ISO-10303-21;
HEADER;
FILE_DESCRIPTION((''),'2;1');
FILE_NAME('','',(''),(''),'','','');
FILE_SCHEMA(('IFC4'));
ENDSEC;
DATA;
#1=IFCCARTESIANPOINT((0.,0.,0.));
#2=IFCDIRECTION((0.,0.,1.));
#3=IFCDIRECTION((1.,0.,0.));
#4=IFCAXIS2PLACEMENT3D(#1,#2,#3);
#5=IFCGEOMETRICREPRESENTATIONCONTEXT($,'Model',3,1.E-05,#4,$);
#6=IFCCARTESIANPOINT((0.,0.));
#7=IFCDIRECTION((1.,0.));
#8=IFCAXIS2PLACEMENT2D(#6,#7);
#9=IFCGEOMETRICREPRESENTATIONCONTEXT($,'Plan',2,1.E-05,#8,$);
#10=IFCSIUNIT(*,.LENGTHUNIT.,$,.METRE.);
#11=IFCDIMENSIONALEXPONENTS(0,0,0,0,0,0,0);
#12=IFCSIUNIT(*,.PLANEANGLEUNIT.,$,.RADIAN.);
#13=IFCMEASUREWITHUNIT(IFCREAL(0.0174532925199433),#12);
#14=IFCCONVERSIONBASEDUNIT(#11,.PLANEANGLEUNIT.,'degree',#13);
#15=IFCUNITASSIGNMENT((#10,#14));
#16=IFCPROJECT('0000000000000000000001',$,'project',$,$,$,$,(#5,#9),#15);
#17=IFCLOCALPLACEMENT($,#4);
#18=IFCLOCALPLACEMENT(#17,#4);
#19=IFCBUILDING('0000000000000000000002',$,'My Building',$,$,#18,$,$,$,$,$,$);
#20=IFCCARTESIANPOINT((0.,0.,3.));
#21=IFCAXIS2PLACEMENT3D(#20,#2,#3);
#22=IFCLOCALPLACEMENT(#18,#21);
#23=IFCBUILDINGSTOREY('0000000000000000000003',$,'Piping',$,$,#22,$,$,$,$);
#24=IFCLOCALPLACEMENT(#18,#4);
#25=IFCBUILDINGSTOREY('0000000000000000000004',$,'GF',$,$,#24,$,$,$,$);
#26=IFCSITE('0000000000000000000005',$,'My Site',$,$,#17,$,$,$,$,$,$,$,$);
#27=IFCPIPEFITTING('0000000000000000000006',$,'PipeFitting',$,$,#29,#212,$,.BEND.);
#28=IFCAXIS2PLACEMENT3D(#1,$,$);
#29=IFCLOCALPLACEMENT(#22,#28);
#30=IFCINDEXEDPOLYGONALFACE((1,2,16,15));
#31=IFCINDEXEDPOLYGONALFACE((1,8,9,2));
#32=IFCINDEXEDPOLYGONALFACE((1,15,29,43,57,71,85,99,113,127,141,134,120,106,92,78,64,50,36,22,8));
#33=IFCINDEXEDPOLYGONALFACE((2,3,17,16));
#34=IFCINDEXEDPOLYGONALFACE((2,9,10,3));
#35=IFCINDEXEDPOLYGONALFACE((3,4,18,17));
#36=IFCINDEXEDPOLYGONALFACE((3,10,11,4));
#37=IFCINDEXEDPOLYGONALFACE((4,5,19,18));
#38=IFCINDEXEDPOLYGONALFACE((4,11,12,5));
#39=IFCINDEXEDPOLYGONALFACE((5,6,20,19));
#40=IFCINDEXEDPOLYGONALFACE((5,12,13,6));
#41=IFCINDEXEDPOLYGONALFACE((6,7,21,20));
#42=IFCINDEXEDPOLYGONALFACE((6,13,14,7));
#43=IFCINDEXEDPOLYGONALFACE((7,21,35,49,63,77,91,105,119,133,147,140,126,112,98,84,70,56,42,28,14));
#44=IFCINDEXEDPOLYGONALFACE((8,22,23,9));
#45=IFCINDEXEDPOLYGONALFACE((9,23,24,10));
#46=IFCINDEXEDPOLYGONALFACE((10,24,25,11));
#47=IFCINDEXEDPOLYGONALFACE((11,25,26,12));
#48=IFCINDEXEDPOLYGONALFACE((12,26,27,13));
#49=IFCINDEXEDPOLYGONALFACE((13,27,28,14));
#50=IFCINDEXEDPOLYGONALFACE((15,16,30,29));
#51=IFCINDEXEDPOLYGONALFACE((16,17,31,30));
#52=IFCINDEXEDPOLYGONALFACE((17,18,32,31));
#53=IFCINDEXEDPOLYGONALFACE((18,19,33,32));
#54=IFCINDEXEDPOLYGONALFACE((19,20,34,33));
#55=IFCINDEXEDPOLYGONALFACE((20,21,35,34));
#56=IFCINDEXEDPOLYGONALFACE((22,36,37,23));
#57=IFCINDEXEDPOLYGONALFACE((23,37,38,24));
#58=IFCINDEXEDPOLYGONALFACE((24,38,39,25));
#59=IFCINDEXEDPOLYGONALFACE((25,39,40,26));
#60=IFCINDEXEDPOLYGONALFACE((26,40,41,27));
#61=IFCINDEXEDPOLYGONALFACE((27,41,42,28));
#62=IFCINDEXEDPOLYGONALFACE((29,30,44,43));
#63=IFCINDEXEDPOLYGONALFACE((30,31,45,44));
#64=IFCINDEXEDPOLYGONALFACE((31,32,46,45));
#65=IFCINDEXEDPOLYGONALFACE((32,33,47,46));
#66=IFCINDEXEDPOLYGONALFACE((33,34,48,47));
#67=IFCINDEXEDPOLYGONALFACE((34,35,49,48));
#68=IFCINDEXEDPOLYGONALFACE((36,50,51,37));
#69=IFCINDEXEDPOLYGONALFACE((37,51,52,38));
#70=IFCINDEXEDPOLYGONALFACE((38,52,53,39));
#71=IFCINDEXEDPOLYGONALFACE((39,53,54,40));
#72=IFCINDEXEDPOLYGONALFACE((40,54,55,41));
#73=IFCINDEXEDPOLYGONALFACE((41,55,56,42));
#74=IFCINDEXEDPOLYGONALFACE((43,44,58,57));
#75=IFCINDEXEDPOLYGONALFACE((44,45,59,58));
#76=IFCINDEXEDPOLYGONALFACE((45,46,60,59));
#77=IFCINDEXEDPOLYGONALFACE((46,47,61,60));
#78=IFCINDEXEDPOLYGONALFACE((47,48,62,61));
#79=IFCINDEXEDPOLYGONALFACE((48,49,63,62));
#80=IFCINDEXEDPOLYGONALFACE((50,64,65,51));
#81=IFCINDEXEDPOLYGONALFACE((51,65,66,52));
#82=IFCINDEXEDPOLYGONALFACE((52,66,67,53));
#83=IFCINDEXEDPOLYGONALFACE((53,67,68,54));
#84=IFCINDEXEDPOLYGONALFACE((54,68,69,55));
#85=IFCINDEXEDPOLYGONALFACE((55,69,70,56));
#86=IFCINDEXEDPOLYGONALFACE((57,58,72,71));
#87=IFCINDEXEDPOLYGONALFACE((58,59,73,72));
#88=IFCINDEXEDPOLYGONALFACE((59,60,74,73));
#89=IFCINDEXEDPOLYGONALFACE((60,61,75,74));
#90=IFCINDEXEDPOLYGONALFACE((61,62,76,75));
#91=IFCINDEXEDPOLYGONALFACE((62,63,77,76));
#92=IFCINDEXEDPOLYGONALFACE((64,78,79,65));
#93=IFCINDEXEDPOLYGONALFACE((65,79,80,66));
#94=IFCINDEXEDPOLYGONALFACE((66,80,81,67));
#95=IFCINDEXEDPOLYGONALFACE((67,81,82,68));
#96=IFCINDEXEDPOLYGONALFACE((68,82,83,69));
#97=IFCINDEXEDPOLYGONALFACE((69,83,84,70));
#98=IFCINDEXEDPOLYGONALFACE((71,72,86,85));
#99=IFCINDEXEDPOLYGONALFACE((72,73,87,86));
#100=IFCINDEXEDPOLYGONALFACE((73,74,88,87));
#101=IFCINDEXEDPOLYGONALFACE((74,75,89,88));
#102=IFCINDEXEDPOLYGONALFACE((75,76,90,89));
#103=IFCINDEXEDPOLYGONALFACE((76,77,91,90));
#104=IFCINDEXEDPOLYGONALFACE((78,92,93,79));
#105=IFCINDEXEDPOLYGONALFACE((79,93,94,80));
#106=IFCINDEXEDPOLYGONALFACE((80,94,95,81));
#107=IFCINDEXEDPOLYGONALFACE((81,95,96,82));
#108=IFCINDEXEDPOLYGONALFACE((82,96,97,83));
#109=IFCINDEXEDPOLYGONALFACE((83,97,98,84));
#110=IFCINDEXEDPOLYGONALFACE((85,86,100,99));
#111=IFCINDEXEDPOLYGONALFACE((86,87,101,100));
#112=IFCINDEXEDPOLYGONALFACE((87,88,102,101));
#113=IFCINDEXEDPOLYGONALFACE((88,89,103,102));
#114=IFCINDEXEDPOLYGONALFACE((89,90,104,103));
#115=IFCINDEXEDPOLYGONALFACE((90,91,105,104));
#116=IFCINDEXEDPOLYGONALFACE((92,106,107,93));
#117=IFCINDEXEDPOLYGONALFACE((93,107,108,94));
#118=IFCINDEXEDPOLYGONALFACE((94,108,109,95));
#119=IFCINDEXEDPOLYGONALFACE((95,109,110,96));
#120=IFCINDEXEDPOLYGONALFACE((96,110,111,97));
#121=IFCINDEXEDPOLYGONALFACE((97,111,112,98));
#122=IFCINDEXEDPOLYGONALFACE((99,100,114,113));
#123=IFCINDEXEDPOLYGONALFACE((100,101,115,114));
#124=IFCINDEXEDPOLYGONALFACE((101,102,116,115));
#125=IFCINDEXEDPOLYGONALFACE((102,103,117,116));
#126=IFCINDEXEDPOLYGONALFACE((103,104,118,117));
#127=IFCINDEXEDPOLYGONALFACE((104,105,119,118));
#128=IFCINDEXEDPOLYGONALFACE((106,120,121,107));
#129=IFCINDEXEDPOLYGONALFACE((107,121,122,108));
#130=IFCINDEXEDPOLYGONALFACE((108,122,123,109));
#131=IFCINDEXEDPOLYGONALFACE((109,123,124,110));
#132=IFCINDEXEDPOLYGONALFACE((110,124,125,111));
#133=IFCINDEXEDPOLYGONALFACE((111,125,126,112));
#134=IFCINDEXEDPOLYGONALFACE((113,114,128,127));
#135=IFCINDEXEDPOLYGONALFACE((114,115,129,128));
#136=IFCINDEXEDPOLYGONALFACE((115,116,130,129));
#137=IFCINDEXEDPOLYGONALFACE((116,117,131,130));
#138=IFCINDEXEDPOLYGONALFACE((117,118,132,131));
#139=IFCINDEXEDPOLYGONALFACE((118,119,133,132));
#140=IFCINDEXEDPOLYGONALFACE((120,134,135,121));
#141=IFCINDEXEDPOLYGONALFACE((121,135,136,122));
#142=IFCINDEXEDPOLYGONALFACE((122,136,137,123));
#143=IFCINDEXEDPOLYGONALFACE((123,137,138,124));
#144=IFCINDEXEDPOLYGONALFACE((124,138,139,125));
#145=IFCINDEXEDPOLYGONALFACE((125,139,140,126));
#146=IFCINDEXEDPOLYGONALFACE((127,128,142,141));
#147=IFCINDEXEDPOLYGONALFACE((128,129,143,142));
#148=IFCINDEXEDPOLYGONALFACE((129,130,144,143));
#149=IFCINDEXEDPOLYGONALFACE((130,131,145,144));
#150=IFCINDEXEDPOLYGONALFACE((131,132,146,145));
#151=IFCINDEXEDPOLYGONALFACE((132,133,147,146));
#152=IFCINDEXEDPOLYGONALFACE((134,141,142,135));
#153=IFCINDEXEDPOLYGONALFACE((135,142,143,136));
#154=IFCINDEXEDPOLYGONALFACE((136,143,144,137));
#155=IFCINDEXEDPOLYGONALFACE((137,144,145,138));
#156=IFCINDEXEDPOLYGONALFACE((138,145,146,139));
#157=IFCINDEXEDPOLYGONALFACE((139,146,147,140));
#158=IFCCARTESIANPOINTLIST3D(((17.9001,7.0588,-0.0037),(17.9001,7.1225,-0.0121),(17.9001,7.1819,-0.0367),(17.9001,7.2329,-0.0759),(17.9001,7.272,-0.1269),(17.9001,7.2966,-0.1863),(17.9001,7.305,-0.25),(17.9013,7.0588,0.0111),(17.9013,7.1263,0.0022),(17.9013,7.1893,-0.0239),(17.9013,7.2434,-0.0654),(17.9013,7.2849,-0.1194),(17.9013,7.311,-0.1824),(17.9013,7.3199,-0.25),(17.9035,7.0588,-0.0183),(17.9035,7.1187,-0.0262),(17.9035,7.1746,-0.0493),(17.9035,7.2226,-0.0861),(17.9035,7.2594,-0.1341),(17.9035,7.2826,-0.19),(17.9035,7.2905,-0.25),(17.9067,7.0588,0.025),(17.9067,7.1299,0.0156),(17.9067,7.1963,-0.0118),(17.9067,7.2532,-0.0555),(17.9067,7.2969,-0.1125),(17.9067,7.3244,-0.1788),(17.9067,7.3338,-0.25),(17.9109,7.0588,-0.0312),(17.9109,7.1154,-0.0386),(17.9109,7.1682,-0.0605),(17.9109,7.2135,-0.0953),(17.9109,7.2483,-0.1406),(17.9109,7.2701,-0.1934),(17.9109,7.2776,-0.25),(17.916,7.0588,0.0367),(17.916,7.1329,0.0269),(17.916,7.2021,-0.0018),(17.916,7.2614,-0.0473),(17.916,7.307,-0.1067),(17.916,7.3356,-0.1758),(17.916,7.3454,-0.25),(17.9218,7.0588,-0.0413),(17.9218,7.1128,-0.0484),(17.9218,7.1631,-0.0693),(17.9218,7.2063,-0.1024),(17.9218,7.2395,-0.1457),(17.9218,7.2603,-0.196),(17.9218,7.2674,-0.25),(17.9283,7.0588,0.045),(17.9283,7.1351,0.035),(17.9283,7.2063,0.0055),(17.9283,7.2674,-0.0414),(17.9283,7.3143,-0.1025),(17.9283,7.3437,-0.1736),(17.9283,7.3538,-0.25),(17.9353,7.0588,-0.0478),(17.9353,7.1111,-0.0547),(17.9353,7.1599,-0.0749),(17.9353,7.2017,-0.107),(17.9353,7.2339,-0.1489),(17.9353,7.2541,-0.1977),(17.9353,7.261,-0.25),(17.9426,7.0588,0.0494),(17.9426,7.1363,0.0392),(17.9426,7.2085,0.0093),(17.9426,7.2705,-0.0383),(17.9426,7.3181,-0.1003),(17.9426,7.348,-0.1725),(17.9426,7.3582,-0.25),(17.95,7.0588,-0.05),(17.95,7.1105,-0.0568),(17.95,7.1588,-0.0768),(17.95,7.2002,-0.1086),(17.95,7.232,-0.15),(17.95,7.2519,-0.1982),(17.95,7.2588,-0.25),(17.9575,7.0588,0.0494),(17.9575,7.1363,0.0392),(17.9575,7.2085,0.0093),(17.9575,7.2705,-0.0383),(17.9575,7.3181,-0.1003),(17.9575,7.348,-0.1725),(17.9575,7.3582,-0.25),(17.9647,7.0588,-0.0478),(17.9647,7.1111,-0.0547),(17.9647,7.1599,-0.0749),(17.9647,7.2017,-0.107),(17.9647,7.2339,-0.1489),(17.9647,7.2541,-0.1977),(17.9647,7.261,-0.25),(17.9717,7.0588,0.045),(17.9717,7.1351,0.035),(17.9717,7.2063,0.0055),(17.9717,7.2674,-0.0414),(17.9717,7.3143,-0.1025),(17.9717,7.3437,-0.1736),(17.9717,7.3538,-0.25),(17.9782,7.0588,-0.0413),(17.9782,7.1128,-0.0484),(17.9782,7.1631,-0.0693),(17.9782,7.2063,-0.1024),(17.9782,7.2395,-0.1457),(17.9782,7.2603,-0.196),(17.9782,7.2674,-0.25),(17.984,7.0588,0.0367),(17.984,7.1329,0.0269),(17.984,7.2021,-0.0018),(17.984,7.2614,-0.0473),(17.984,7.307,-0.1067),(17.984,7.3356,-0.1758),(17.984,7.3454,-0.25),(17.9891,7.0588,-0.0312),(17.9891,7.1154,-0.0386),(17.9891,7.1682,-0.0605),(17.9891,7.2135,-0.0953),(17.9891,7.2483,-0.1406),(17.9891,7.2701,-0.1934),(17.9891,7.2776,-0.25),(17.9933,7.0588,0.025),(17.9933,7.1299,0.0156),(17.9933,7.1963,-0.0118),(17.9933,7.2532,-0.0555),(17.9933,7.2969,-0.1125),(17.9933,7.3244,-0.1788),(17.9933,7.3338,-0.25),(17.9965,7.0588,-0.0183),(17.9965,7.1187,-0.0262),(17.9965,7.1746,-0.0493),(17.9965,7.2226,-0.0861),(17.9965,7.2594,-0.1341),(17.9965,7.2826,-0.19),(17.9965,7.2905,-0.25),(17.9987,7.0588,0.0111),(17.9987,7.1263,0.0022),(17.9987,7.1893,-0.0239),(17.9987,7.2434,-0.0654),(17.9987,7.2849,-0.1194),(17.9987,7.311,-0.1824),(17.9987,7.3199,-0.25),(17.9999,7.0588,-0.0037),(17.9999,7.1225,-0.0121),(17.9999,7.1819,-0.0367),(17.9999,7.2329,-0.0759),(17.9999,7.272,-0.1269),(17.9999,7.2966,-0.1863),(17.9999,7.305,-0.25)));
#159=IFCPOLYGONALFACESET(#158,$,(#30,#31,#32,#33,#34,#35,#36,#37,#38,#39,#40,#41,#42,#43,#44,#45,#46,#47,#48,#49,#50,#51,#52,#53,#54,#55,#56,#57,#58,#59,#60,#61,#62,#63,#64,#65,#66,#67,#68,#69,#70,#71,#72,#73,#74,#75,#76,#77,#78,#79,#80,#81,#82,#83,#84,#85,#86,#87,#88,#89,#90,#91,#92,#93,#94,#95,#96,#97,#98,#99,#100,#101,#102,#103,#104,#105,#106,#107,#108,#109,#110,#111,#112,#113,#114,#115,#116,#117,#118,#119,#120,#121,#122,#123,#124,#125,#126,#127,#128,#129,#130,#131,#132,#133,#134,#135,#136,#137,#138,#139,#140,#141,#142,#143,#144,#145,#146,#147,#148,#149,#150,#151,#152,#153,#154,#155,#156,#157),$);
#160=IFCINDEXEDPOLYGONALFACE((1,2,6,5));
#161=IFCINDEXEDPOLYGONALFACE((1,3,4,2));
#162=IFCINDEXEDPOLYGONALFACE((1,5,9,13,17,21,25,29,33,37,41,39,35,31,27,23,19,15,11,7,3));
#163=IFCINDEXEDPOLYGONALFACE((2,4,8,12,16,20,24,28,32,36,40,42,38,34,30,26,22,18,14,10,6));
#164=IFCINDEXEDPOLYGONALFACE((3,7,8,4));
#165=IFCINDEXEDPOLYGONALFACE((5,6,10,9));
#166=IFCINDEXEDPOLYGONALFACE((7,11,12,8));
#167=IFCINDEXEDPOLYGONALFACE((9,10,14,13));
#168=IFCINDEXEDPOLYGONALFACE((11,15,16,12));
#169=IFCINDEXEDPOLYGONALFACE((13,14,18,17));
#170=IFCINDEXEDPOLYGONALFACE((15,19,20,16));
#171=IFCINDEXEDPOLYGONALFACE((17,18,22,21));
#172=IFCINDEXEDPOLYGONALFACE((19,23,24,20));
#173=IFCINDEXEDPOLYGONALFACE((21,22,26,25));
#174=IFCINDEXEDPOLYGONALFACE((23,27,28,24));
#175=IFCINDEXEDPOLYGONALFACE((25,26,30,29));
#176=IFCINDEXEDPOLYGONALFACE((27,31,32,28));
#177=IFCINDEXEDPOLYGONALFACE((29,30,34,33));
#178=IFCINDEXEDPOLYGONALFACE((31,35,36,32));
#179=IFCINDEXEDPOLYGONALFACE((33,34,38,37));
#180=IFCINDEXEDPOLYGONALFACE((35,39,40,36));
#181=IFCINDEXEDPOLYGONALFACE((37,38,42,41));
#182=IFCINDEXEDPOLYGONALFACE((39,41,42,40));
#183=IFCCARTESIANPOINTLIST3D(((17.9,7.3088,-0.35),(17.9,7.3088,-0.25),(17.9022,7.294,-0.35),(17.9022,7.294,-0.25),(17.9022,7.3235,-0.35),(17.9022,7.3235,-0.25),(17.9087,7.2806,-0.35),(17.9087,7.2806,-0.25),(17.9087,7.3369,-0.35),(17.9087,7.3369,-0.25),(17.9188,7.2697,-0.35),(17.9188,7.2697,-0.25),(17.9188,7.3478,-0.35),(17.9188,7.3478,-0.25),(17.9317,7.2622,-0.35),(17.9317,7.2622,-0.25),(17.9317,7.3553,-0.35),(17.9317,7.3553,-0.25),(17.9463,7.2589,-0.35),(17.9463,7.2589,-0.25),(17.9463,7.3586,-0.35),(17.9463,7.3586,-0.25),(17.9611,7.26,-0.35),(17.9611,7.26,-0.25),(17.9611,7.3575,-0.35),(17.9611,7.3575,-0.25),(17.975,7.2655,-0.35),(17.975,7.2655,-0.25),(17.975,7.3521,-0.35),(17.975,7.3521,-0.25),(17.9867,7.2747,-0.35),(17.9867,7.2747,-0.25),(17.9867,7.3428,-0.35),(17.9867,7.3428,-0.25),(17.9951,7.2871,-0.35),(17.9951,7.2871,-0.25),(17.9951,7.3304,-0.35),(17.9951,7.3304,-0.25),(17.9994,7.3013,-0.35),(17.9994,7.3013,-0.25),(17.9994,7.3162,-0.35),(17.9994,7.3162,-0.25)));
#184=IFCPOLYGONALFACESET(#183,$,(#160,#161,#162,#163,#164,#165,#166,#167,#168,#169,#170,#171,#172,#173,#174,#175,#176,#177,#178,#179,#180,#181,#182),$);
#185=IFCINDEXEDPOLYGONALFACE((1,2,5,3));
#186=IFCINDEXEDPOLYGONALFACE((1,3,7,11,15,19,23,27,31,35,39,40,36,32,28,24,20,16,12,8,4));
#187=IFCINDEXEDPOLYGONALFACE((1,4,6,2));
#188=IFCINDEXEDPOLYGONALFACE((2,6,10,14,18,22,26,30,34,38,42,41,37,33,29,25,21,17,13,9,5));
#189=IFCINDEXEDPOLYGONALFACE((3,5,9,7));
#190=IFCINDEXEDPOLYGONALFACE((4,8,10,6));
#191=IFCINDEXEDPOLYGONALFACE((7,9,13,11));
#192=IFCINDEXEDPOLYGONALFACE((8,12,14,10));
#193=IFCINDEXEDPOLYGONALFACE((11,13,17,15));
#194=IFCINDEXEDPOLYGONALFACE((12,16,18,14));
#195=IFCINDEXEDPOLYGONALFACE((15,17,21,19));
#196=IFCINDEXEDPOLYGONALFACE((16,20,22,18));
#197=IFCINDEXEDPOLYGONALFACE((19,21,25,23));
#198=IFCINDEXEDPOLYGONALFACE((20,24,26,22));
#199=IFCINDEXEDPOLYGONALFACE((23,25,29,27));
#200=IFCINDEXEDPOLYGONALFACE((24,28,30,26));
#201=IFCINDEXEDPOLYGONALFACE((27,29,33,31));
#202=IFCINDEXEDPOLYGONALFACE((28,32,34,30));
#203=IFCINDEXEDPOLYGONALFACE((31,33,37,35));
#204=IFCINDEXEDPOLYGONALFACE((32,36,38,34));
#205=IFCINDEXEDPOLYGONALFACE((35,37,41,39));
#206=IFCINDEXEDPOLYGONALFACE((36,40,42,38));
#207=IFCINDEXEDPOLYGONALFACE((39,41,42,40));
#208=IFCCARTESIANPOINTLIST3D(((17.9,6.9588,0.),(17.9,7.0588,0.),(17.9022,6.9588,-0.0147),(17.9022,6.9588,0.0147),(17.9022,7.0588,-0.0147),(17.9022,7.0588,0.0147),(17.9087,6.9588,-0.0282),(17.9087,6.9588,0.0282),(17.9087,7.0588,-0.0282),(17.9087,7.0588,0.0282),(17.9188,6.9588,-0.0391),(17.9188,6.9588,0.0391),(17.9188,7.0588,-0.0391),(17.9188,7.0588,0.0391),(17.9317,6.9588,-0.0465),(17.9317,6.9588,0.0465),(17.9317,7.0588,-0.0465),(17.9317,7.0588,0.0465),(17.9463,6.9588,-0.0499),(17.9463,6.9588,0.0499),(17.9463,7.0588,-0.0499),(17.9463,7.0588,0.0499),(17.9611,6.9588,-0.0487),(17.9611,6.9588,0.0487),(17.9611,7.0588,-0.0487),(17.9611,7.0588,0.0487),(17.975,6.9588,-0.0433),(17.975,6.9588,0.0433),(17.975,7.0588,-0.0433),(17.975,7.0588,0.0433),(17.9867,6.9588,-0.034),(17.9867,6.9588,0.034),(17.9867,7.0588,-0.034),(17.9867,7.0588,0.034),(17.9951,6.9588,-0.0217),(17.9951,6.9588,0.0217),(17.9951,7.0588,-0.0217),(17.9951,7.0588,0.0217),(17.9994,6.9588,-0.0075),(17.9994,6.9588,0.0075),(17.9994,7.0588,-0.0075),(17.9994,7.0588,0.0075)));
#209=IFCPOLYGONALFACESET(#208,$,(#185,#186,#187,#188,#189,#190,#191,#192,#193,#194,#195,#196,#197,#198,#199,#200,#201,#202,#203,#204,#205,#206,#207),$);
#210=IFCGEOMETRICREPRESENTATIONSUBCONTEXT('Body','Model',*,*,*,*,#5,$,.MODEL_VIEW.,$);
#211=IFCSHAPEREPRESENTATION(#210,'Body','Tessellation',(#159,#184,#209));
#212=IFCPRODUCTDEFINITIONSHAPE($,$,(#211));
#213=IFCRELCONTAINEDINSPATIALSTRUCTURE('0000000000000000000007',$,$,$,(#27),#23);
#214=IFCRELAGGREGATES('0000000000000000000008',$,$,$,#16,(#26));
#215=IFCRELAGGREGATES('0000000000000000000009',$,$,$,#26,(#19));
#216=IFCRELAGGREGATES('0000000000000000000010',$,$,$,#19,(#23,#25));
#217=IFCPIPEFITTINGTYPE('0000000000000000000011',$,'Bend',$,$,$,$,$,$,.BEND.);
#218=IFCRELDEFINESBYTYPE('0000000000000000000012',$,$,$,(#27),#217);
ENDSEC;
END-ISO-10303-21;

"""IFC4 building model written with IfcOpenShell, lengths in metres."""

from ifc_helpers import new_model, entity, si_unit, converted_unit, frame, origin_with_axes, origin_2d_with_axis, place, context, subcontext, project, spatial, circle, extrude, source, transform, mapped, type_object, type_shapes, element, save


model = new_model("IFC4")

# Units and contexts
model_context = context("Model", 3, precision=1e-05, world=origin_with_axes())
plan_context = context("Plan", 2, precision=1e-05, world=origin_2d_with_axis())
body_context_1 = subcontext(model_context, "Body", "Model", "MODEL_VIEW")
ifc_project = project(units=[si_unit("LENGTHUNIT", "METRE"), converted_unit("PLANEANGLEUNIT", "degree", entity("IfcReal", 0.0174532925199433), si_unit("PLANEANGLEUNIT", "RADIAN"), dimensions=[0, 0, 0, 0, 0, 0, 0])], contexts=[model_context, plan_context])

# Site, building, storey
site_placement = place(None, origin_with_axes())
site = spatial("IfcSite", under=ifc_project, at=site_placement, Name="My Site")
building_placement = place(site_placement, origin_with_axes())
building = spatial("IfcBuilding", under=site, at=building_placement, Name="My Building")
storey_1_placement = place(building_placement, frame((0.0, 0.0, 3.0), z_axis=(0.0, 0.0, 1.0), x_axis=(1.0, 0.0, 0.0)))
storey_1 = spatial("IfcBuildingStorey", under=building, at=storey_1_placement, Name="Piping")

# Shared definitions
storey_2_placement = place(building_placement, origin_with_axes())
storey_2 = spatial("IfcBuildingStorey", under=building, at=storey_2_placement, Name="GF")

# Pipe fitting
pipe_fitting_type_1 = type_object("IfcPipeFittingType", Name="Bend", PredefinedType="BEND")
shared_shape_1 = source(origin_with_axes(), body_context_1, "Body", "SolidModel", [
    entity("IfcSweptDiskSolid", entity("IfcIndexedPolyCurve", entity("IfcCartesianPointList3D", [[0.0, 0.0, -0.1], [0.0, -0.0732, -0.2768], [0.0, -0.25, -0.35]]), [entity("IfcArcIndex", [1, 2, 3])]), 0.05),
    extrude(circle(Radius=0.05), origin_with_axes(), (0.0, 0.0, -1.0), 0.1),
    extrude(circle(Radius=0.05), frame((0.0, -0.25, -0.35), z_axis=(0.0, -1.0, 0.0), x_axis=(1.0, 0.0, 0.0)), (0.0, 0.0, 1.0), 0.1),
])
type_shapes(pipe_fitting_type_1, [shared_shape_1])
for number, where, z_axis, x_axis, name in (
    (1, (17.95, 7.3088, -0.35), (0.0, 0.0, -1.0), (-1.0, 0.0, 0.0), "PipeFitting"),
):
    element("IfcPipeFitting", number, at=place(storey_1_placement, frame(where, z_axis=z_axis, x_axis=x_axis)), inside=storey_1, type_object=pipe_fitting_type_1, Name=name, PredefinedType="BEND", context=body_context_1, shape_type="MappedRepresentation", body=[
        mapped(shared_shape_1, transform((0.0, 0.0, 0.0), x_axis=(1.0, 0.0, 0.0), y_axis=(0.0, 1.0, 0.0), z_axis=(0.0, 0.0, 1.0), scale=1.0)),
    ])

save(model, "model.ifc")
